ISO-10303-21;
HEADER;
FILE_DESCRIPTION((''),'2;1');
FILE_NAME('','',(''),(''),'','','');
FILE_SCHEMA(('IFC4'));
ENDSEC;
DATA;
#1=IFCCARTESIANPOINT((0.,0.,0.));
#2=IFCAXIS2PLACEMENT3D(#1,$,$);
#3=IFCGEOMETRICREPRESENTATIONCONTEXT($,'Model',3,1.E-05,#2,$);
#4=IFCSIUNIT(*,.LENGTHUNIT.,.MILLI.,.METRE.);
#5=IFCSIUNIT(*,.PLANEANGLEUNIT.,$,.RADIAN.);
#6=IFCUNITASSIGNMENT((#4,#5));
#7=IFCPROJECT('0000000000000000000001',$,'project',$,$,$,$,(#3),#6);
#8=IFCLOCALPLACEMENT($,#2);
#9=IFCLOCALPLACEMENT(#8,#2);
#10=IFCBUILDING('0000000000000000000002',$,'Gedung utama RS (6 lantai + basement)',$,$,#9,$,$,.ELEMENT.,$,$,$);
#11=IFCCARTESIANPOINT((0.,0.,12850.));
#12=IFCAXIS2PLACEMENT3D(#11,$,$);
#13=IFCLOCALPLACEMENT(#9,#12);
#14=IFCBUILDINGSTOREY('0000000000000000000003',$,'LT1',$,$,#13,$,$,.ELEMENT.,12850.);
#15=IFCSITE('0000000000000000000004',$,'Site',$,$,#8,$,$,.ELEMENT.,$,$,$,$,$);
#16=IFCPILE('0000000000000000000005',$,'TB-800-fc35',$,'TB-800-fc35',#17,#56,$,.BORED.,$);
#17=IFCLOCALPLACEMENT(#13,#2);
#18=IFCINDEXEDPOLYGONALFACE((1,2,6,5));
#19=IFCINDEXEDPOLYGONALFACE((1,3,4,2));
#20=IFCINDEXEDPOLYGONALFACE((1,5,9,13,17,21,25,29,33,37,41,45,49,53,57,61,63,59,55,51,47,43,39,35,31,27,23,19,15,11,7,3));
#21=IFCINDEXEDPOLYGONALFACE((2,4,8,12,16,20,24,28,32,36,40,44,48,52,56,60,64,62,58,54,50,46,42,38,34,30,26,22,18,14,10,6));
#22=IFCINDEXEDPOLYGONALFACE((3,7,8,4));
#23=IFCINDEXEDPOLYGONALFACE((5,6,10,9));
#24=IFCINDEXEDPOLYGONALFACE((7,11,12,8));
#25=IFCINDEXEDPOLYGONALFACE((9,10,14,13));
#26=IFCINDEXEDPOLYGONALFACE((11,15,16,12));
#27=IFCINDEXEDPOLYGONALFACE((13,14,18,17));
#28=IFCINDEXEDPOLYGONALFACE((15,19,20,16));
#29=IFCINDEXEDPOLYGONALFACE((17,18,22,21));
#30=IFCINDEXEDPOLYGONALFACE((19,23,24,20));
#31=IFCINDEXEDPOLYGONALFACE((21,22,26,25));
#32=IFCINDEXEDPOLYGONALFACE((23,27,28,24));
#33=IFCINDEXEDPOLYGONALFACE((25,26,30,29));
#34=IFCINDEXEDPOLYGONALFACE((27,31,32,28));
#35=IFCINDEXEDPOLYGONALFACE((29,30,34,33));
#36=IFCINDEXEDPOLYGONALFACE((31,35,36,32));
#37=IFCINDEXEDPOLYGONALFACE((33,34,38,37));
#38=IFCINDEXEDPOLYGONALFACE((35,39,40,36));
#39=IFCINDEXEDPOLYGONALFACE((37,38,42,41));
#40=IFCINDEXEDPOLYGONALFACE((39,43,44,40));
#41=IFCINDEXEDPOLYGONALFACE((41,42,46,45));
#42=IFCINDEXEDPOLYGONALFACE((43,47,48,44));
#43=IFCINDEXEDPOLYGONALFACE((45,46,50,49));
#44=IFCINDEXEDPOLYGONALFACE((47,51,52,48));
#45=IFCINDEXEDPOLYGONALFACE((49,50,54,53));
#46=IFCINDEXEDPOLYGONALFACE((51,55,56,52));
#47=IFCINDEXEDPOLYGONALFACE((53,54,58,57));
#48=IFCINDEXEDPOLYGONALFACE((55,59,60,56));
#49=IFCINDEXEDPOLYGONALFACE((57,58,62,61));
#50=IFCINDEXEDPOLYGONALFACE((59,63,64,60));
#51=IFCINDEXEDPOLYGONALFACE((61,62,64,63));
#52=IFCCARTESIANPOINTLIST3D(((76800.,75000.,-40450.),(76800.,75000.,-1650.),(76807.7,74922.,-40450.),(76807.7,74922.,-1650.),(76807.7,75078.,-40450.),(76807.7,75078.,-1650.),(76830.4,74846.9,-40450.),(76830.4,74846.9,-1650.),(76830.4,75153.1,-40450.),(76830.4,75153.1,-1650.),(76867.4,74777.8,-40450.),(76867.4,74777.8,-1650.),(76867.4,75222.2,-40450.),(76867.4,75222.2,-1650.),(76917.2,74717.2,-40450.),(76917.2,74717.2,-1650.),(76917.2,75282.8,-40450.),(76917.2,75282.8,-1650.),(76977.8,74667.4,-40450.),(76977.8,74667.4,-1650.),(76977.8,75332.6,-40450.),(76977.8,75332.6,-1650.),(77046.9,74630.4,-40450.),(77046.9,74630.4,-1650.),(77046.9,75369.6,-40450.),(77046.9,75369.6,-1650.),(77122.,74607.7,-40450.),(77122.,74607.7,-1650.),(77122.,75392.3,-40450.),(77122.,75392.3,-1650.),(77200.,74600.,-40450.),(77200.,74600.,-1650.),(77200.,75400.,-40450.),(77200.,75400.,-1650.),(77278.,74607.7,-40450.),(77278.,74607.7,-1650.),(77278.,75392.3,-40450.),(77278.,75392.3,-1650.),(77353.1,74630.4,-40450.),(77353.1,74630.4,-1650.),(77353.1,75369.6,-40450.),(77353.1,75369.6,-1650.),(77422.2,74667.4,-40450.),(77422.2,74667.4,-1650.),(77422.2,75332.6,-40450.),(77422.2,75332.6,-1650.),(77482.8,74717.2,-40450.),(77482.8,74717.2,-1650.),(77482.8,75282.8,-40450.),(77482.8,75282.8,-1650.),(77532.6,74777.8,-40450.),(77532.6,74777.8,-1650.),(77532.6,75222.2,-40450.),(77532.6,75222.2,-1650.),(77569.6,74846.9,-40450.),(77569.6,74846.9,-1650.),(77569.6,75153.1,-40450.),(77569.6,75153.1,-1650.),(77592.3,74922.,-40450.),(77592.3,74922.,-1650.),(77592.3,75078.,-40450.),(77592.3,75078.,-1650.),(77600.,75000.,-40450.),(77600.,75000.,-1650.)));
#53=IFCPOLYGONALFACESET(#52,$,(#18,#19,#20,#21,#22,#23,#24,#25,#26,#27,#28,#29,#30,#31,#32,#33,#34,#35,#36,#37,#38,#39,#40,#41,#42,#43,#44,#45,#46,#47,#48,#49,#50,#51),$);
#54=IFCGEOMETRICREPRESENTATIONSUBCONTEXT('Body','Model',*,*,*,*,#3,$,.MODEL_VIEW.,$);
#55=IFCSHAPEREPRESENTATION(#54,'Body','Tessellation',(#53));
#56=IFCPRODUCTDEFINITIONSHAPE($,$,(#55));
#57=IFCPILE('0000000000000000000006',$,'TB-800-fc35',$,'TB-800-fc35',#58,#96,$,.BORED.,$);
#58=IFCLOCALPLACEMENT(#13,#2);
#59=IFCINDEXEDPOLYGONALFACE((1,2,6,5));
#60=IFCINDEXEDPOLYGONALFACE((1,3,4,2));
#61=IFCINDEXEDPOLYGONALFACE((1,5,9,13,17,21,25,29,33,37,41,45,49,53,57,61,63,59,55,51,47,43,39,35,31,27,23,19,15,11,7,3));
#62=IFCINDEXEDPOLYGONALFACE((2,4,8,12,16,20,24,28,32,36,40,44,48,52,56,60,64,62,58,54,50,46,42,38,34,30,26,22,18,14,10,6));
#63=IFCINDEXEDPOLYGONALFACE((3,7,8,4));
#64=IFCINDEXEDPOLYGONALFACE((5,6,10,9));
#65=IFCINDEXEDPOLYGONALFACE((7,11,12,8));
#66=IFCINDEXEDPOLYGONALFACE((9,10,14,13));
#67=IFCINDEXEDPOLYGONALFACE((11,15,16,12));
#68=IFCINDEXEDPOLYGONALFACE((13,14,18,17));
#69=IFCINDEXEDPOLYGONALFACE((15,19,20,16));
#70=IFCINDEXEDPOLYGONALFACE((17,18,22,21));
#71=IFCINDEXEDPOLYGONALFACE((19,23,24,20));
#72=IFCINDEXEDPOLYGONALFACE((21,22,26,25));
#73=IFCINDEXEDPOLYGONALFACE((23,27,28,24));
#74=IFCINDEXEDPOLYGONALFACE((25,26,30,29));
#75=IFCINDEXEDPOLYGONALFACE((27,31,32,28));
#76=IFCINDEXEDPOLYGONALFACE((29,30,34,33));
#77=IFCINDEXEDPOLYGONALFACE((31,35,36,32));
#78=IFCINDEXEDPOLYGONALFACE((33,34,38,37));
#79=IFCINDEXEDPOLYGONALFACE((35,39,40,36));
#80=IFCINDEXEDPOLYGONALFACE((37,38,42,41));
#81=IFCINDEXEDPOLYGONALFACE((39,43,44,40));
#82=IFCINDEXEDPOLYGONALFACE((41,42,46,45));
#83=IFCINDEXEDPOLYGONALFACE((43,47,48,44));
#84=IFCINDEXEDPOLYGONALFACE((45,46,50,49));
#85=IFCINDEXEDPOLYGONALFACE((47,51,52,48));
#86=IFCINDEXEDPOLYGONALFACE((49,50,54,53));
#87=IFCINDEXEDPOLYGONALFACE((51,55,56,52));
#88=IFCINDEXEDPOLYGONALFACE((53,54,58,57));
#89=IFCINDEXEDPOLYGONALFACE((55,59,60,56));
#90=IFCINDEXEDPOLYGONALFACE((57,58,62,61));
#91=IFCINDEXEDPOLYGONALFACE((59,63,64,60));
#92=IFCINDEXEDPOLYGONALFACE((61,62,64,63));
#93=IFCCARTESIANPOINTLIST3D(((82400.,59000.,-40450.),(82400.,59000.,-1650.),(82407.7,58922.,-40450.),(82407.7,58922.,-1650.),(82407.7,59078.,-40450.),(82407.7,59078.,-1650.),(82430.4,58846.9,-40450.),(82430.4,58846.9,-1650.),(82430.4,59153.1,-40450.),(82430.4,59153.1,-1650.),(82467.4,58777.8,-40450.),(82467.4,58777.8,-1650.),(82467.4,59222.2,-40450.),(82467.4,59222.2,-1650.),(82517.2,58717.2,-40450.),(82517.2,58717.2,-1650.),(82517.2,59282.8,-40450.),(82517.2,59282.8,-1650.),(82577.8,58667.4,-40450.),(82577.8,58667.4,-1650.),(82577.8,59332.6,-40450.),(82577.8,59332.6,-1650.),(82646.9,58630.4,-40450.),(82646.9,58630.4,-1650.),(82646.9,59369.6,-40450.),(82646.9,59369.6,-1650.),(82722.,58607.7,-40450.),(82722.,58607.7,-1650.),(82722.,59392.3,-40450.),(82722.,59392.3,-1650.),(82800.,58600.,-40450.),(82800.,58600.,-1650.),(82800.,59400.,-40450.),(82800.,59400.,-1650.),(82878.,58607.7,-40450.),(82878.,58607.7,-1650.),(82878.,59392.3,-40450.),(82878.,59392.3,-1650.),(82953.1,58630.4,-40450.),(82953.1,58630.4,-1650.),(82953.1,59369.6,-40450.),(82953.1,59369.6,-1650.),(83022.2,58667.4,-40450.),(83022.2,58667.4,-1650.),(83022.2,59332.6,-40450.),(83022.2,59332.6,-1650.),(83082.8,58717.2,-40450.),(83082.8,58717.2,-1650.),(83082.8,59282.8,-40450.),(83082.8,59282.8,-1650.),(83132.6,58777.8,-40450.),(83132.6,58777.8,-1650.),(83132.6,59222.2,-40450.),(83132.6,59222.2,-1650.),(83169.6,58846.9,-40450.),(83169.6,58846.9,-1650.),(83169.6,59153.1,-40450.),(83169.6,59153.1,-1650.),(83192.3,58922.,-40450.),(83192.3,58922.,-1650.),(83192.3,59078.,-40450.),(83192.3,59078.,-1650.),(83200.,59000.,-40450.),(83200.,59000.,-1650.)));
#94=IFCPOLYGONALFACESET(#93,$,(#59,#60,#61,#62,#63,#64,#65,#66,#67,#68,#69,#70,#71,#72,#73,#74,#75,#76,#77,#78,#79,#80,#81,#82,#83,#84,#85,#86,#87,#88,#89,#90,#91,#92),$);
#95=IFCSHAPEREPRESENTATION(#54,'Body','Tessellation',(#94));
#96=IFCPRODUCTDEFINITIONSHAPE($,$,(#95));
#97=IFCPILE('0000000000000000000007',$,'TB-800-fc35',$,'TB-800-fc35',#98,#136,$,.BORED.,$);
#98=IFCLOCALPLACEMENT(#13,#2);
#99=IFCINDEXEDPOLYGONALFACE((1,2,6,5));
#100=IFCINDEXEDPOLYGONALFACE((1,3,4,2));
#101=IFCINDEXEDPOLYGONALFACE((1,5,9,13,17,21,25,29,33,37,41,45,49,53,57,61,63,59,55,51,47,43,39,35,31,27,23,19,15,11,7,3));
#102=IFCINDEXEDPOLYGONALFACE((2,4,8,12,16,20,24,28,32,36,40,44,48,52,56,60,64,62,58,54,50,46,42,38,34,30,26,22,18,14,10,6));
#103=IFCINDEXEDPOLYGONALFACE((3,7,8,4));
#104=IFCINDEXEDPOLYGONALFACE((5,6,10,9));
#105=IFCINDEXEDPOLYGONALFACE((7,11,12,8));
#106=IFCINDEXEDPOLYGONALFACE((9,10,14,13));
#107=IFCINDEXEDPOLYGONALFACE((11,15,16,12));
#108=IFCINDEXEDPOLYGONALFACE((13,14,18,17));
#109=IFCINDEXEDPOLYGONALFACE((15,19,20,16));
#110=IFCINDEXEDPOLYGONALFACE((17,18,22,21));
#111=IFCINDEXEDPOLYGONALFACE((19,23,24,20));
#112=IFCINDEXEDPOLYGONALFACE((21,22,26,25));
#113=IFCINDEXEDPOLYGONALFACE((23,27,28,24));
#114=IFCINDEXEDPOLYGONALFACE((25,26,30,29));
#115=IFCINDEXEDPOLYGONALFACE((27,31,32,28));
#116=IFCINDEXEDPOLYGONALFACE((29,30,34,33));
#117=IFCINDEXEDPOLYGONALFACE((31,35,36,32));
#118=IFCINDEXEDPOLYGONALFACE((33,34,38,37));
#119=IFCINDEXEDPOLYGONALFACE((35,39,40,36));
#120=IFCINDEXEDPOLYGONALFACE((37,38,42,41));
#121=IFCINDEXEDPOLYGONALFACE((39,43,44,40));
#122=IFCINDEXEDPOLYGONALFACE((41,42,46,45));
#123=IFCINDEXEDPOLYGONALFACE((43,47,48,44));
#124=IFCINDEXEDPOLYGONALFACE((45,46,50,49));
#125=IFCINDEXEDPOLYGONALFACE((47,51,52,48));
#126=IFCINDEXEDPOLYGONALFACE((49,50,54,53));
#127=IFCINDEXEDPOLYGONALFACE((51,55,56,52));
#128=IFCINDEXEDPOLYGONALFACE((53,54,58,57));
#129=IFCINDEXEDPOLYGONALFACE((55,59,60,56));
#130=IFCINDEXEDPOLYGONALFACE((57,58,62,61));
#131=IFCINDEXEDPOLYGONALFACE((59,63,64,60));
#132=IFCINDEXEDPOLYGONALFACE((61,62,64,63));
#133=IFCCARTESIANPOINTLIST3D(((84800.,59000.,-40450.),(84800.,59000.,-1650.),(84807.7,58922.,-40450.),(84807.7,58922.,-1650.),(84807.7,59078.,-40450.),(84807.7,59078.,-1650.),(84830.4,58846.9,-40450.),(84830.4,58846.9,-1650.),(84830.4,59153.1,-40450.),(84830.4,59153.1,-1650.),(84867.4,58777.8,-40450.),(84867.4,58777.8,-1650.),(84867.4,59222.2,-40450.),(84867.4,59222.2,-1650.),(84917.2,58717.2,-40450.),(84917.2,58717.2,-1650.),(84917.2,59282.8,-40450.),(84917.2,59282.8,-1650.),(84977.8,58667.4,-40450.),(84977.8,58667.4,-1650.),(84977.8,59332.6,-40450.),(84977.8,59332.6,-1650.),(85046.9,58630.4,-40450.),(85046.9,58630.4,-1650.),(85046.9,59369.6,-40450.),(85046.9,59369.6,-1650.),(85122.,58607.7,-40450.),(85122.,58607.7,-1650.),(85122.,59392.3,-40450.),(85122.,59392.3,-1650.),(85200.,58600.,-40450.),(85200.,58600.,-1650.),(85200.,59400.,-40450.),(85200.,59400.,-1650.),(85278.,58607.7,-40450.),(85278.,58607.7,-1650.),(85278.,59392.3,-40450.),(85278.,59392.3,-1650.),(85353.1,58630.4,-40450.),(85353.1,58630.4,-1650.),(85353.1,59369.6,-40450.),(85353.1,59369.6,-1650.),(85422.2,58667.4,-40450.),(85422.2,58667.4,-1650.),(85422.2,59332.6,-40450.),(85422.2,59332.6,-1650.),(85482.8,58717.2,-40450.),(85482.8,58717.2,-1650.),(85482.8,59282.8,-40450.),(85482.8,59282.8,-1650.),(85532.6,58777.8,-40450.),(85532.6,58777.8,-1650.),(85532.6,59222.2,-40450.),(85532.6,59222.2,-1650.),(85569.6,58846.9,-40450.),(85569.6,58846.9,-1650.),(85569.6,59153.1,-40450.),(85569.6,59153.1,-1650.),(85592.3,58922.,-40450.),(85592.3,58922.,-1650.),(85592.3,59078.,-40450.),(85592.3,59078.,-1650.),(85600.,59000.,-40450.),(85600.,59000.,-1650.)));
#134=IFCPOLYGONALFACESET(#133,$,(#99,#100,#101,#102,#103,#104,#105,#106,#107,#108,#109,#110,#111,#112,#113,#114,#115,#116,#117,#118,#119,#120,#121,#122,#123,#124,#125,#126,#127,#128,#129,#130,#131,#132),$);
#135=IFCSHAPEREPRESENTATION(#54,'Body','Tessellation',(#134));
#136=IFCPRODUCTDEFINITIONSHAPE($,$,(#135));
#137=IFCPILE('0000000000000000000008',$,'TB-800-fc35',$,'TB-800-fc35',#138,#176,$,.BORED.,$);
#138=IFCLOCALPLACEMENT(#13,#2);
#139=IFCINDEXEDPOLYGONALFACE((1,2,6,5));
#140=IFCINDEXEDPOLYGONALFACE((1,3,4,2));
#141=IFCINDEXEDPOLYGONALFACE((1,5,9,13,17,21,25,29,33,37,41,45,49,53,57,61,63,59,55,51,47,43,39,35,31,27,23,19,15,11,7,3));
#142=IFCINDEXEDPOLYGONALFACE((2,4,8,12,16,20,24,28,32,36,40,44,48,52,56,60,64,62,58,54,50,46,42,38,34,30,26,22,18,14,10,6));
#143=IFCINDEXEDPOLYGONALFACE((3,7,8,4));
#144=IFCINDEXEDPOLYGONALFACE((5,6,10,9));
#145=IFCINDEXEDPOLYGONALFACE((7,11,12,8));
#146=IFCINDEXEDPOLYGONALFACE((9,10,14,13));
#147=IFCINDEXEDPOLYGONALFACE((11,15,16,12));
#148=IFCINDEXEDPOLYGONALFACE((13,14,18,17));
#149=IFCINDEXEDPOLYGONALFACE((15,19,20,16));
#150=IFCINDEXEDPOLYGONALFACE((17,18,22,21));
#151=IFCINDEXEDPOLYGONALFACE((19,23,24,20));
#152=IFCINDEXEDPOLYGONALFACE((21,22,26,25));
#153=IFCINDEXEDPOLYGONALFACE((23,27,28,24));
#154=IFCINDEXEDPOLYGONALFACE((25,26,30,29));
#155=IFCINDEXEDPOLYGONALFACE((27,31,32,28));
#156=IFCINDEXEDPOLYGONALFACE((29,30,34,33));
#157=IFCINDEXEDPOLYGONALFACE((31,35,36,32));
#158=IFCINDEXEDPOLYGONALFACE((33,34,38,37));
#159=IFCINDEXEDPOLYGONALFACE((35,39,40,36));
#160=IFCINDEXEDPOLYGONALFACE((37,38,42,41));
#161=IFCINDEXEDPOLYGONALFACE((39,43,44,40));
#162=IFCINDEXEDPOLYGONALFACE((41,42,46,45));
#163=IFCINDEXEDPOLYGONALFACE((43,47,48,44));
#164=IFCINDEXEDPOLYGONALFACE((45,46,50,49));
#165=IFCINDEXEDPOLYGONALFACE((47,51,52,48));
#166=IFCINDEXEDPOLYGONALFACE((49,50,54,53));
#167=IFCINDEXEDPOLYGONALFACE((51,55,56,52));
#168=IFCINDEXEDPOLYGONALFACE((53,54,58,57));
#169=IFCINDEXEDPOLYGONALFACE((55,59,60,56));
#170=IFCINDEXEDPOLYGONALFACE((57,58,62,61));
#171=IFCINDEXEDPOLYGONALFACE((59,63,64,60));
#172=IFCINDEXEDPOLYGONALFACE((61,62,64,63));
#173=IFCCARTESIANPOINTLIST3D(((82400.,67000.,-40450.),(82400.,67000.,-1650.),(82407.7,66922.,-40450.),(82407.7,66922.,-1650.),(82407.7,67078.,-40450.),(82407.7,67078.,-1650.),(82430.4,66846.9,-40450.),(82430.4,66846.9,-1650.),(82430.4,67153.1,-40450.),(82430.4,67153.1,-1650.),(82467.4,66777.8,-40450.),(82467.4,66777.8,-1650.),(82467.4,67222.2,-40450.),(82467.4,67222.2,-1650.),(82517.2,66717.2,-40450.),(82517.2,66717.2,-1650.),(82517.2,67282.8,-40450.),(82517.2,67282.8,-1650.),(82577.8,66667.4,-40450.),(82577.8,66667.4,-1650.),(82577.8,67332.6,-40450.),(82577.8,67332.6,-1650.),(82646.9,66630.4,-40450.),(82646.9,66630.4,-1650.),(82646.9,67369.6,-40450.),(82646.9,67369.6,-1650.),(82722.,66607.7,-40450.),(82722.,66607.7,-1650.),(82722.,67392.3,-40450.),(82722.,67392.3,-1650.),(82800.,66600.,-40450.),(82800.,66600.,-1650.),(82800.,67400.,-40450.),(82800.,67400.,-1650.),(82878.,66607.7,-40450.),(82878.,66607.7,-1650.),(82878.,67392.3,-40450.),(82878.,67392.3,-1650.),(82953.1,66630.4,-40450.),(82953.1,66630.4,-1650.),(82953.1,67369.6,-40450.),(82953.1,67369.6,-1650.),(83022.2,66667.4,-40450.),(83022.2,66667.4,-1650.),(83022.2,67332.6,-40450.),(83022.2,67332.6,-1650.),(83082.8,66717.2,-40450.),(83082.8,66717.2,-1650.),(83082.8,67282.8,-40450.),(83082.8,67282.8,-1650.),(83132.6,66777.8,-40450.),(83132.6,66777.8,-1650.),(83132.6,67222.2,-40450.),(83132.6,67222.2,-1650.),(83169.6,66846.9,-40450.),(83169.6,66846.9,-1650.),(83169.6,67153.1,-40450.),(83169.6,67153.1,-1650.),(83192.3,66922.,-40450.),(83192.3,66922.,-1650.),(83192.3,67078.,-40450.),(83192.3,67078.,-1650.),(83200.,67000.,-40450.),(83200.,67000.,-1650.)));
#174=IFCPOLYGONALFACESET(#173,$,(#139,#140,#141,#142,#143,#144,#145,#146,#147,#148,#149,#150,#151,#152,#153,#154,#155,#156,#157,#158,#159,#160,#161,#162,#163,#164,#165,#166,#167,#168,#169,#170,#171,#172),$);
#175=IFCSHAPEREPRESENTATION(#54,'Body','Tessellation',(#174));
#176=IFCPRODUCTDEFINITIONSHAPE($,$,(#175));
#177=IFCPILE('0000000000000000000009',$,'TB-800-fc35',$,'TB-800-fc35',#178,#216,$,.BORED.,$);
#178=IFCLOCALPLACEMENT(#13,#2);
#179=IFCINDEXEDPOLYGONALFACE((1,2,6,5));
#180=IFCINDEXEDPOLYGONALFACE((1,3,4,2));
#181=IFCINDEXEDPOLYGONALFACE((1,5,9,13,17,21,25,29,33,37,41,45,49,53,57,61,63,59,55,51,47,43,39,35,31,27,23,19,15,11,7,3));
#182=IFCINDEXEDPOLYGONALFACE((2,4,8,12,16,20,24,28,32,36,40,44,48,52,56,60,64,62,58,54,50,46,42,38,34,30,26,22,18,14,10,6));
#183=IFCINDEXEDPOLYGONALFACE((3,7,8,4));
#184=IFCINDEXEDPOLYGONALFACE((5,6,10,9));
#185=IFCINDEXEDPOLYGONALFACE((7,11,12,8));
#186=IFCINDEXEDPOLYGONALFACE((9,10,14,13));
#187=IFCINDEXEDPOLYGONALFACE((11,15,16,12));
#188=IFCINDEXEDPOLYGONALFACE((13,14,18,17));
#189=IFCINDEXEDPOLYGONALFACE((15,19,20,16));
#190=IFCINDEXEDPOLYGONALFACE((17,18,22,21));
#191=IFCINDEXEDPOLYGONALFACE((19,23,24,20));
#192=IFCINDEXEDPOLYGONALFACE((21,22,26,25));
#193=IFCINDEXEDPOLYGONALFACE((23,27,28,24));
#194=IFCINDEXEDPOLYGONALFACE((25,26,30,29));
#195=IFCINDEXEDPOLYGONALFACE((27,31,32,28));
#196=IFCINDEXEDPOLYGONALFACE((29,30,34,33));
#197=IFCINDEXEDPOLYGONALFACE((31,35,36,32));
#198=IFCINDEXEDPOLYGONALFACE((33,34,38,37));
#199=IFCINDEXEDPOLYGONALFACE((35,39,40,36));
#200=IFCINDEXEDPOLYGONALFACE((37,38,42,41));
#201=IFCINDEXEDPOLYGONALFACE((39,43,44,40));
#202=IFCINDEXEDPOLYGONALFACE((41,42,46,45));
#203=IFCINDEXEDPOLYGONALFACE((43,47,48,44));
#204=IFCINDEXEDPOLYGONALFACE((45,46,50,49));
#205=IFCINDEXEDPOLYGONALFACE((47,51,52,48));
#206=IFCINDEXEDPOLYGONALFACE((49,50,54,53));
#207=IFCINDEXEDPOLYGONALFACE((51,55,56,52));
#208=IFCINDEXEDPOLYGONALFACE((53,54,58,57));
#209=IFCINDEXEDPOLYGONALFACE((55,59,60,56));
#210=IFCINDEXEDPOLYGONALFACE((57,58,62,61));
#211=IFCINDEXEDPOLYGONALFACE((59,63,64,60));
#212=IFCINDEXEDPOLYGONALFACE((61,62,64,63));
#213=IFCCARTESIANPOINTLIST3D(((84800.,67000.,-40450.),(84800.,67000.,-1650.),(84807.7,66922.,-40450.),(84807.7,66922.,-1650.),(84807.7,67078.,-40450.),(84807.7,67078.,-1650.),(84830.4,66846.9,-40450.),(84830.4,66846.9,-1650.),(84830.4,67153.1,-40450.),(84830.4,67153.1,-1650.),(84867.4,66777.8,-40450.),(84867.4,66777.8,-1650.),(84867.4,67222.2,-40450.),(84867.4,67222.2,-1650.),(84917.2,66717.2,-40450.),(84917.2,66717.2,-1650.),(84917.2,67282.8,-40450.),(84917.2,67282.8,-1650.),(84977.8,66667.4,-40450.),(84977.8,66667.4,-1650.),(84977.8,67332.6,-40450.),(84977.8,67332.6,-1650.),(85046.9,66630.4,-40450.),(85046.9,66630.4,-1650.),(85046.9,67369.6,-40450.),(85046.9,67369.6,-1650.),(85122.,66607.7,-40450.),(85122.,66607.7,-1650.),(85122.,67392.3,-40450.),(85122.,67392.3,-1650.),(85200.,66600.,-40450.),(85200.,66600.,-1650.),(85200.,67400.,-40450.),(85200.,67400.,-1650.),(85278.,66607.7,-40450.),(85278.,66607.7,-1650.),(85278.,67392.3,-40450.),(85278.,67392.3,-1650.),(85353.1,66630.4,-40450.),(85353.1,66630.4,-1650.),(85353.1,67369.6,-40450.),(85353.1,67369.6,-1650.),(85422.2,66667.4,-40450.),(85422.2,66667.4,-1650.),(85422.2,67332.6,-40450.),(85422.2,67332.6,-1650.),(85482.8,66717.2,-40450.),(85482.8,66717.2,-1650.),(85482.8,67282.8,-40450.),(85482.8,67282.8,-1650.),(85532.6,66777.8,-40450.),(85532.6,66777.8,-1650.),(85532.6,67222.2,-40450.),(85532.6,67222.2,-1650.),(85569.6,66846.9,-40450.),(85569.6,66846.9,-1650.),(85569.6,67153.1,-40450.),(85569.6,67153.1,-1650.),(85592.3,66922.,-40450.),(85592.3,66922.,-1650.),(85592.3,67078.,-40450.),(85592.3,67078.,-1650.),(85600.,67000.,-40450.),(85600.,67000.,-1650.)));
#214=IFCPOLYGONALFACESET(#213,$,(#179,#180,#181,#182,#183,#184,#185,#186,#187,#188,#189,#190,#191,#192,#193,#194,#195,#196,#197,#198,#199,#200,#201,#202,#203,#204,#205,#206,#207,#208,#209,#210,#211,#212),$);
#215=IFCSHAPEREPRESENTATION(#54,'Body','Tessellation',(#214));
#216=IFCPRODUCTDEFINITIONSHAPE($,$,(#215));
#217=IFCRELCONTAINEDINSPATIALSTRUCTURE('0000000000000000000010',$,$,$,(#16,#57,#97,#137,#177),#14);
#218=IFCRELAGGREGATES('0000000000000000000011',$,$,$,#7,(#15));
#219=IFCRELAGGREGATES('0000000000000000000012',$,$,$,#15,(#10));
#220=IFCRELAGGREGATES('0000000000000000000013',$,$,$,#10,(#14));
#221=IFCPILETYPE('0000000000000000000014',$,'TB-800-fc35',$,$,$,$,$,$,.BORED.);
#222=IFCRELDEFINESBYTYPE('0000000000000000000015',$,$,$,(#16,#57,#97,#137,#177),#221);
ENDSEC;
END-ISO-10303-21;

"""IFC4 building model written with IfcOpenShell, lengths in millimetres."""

from ifc_helpers import new_model, si_unit, frame, origin, origin_2d, place, context, subcontext, project, spatial, circle, extrude, material_profile, profile_set, profile_usage, type_object, element, save


model = new_model("IFC4")

# Units and contexts
model_context = context("Model", 3, precision=1e-05, world=origin())
body_context = subcontext(model_context, "Body", "Model", "MODEL_VIEW")
ifc_project = project(units=[si_unit("LENGTHUNIT", "METRE", prefix="MILLI"), si_unit("PLANEANGLEUNIT", "RADIAN")], contexts=[model_context])

# Site, building, storey
site_placement = place(None, origin())
site = spatial("IfcSite", under=ifc_project, at=site_placement, Name="Site", CompositionType="ELEMENT")
building_placement = place(site_placement, origin())
building = spatial("IfcBuilding", under=site, at=building_placement, Name="Gedung utama RS (6 lantai + basement)", CompositionType="ELEMENT")
storey_placement = place(building_placement, frame((0.0, 0.0, 12850.0)))
storey = spatial("IfcBuildingStorey", under=building, at=storey_placement, Name="LT1", CompositionType="ELEMENT", Elevation=12850.0)

# Piles
ifc_material_profile_1 = material_profile(None, circle(Radius=400.0, at=origin_2d()), Name="TB-800-fc35")
ifc_profile_set_1 = profile_set([ifc_material_profile_1], Name="TB-800-fc35")
ifc_profile_usage_1 = profile_usage(ifc_profile_set_1, cardinal=5)
pile_type = type_object("IfcPileType", Name="TB-800-fc35", PredefinedType="BORED")
for number, where, z_axis, x_axis, name in (
    (1, (77200.0, 75000.0, -40450.0), (0.0, 0.0, 1.0), (1.0, 0.0, 0.0), "TB-800-fc35"),
    (2, (82800.0, 59000.0, -40450.0), (0.0, 0.0, 1.0), (1.0, 0.0, 0.0), "TB-800-fc35"),
    (3, (85200.0, 59000.0, -40450.0), (0.0, 0.0, 1.0), (1.0, 0.0, 0.0), "TB-800-fc35"),
    (4, (82800.0, 67000.0, -40450.0), (0.0, 0.0, 1.0), (1.0, 0.0, 0.0), "TB-800-fc35"),
    (5, (85200.0, 67000.0, -40450.0), (0.0, 0.0, 1.0), (1.0, 0.0, 0.0), "TB-800-fc35"),
):
    element("IfcPile", number, at=place(storey_placement, frame(where, z_axis=z_axis, x_axis=x_axis)), inside=storey, type_object=pile_type, material=ifc_profile_usage_1, Name=name, ObjectType="TB-800-fc35", PredefinedType="BORED", context=body_context, shape_type="SweptSolid", body=[
        extrude(circle(Radius=400.0, at=origin_2d()), origin(), (0.0, 0.0, 1.0), 38800.0),
    ])

save(model, "model.ifc")
